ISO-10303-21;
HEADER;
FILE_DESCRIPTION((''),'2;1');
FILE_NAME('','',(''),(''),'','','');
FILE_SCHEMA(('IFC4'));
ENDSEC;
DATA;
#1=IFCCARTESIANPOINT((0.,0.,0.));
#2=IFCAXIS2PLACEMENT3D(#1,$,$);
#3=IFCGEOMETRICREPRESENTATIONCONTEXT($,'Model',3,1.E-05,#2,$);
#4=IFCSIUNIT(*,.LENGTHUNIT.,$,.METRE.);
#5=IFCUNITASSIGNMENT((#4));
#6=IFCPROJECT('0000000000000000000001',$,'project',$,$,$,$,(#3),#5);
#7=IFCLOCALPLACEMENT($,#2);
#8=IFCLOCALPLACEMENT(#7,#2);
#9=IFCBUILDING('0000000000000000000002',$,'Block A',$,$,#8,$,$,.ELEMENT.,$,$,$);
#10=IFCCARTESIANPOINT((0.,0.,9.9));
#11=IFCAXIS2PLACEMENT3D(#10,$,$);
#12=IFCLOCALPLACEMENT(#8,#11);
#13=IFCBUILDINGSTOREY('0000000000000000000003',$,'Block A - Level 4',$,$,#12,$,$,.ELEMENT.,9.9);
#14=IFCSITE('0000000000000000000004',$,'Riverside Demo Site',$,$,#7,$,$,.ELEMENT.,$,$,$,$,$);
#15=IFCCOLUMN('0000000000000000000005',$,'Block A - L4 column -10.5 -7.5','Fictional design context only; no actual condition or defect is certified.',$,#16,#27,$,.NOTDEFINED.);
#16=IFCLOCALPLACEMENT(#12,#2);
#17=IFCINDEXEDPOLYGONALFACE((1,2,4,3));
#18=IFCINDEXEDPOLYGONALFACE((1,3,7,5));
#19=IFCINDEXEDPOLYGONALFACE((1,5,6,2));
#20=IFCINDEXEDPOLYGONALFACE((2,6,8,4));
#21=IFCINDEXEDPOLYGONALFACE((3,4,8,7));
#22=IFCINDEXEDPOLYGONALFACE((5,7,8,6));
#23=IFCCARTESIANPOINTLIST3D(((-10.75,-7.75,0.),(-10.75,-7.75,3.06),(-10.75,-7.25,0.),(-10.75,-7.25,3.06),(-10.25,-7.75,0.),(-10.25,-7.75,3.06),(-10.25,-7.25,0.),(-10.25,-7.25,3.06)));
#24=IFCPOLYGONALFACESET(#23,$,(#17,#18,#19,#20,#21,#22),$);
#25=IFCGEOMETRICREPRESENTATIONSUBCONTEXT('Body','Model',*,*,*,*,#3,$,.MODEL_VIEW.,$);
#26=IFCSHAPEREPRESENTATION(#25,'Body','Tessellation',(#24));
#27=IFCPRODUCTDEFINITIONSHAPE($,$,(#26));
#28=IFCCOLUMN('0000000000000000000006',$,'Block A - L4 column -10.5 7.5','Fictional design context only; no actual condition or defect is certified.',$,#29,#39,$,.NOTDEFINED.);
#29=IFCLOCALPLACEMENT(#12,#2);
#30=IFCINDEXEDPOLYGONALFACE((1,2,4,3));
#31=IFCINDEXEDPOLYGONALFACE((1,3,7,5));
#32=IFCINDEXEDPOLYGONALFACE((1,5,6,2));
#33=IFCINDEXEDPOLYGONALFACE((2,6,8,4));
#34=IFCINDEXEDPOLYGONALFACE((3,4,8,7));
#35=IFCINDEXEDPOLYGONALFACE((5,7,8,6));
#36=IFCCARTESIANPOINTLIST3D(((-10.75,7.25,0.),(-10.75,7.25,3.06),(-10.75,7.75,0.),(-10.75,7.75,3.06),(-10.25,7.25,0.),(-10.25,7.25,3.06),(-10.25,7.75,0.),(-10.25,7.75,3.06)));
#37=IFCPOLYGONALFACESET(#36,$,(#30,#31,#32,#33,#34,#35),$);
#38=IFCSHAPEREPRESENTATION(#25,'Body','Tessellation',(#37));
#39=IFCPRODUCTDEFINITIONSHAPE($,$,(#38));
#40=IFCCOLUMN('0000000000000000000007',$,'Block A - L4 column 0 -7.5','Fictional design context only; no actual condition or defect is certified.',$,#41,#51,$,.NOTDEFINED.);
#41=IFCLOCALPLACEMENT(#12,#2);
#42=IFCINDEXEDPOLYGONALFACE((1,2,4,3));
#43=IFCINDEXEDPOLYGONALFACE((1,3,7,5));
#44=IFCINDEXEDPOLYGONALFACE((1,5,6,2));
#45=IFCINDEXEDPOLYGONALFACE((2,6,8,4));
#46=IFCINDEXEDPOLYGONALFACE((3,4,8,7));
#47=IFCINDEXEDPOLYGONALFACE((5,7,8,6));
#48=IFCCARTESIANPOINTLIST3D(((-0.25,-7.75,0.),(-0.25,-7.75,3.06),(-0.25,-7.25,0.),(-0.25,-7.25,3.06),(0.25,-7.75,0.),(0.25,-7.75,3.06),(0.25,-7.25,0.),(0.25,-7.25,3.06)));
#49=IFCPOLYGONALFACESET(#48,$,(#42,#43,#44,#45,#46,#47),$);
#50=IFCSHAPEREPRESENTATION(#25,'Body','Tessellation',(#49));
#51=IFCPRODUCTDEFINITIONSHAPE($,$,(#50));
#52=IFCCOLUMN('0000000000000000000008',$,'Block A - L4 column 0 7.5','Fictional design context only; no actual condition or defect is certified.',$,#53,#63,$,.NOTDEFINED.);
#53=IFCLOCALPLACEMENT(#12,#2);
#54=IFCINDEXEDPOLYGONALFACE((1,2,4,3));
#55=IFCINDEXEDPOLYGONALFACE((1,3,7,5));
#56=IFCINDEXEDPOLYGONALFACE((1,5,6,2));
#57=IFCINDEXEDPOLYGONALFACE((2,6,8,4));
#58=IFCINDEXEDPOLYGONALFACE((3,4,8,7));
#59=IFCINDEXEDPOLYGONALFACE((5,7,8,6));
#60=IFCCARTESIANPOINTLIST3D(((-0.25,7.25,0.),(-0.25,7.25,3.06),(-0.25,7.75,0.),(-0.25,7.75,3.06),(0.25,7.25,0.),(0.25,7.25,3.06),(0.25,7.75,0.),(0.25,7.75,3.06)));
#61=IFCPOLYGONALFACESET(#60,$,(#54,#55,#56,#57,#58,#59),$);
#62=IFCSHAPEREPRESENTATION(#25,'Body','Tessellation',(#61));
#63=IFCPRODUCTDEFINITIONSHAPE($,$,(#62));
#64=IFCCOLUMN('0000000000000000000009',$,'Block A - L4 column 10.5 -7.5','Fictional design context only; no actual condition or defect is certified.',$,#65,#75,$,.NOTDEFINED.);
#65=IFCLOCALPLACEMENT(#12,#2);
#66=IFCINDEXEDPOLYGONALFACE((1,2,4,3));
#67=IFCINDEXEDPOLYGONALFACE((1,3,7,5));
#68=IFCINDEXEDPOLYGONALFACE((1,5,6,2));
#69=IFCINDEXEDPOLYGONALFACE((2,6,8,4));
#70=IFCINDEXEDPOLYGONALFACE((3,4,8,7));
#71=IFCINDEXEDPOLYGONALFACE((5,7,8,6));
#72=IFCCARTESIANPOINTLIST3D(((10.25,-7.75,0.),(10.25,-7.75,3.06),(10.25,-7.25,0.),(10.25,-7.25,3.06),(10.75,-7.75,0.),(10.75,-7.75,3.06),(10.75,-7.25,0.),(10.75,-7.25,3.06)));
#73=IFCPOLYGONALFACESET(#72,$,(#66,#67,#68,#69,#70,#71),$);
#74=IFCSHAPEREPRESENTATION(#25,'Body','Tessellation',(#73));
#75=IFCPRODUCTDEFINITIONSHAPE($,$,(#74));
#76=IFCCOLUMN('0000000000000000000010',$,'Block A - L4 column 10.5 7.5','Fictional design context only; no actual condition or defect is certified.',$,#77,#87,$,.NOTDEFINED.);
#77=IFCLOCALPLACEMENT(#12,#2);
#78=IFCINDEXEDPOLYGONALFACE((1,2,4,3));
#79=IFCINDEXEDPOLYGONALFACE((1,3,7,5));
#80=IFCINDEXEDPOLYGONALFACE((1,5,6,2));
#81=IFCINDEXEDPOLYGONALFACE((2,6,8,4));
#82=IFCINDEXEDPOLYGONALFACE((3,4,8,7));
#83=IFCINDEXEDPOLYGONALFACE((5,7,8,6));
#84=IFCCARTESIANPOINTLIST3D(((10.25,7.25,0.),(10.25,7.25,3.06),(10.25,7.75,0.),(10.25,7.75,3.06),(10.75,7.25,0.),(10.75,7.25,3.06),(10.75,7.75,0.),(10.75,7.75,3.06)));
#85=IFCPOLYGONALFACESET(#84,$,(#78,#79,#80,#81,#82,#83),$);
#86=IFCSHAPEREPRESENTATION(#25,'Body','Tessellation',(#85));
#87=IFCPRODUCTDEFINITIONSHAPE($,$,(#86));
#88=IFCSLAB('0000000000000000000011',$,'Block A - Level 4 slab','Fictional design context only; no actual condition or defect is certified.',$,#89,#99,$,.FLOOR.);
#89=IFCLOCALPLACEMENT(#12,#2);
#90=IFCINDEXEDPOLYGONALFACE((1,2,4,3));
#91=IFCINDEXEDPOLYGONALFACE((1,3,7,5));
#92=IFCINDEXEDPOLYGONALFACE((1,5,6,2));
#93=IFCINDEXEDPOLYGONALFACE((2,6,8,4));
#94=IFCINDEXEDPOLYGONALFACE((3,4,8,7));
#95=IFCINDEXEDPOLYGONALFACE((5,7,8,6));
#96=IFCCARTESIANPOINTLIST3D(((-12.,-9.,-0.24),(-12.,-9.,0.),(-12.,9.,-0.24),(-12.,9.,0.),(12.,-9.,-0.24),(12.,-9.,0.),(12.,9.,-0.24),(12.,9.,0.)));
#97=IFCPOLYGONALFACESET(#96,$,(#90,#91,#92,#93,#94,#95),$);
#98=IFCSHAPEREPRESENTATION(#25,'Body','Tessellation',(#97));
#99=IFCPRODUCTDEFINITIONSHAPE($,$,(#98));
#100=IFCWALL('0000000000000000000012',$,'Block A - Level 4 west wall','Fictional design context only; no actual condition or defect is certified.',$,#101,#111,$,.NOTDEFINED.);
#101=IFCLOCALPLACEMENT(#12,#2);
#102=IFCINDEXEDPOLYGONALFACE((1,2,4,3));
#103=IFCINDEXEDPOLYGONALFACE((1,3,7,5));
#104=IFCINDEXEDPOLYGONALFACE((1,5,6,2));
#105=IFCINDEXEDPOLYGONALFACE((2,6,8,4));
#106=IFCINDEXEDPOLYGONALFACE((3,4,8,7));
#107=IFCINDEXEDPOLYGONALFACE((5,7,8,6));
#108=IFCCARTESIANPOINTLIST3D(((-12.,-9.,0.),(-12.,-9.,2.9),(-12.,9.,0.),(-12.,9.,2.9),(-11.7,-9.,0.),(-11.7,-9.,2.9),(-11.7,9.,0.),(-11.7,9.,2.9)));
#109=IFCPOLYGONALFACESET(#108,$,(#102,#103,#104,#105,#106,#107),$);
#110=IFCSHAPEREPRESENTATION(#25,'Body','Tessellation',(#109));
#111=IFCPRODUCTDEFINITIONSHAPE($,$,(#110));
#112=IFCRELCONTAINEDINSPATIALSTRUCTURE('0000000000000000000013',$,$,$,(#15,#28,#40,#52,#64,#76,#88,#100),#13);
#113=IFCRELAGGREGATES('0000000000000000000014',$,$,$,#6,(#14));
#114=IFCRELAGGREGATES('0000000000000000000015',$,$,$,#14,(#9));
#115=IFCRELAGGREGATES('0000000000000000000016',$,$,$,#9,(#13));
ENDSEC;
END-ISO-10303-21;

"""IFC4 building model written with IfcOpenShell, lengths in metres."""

from ifc_helpers import new_model, si_unit, frame, origin, origin_2d, place, context, subcontext, project, spatial, rectangle, extrude, element, save


model = new_model("IFC4")

# Units and contexts
model_context = context("Model", 3, precision=1e-05, world=origin())
body_context = subcontext(model_context, "Body", "Model", "MODEL_VIEW")
ifc_project = project(units=[si_unit("LENGTHUNIT", "METRE")], contexts=[model_context])

# Site, building, storey
site_placement = place(None, origin())
site = spatial("IfcSite", under=ifc_project, at=site_placement, Name="Riverside Demo Site", CompositionType="ELEMENT")
building_placement = place(site_placement, origin())
building = spatial("IfcBuilding", under=site, at=building_placement, Name="Block A", CompositionType="ELEMENT")
storey_placement = place(building_placement, frame((0.0, 0.0, 9.9)))
storey = spatial("IfcBuildingStorey", under=building, at=storey_placement, Name="Block A - Level 4", CompositionType="ELEMENT", Elevation=9.9)

# Columns
for number, where, name in (
    (1, (-10.5, -7.5, 0.0), "Block A - L4 column -10.5 -7.5"),
    (2, (-10.5, 7.5, 0.0), "Block A - L4 column -10.5 7.5"),
    (3, (0.0, -7.5, 0.0), "Block A - L4 column 0 -7.5"),
    (4, (0.0, 7.5, 0.0), "Block A - L4 column 0 7.5"),
    (5, (10.5, -7.5, 0.0), "Block A - L4 column 10.5 -7.5"),
    (6, (10.5, 7.5, 0.0), "Block A - L4 column 10.5 7.5"),
):
    element("IfcColumn", number, at=place(storey_placement, frame(where)), inside=storey, Name=name, Description="Fictional design context only; no actual condition or defect is certified.", PredefinedType="NOTDEFINED", context=body_context, shape_type="SweptSolid", body=[
        extrude(rectangle(XDim=0.5, YDim=0.5, at=origin_2d()), origin(), (0.0, 0.0, 1.0), 3.06),
    ])

# Slab
slab_placement = place(storey_placement, frame((0.0, 0.0, -0.24)))
element("IfcSlab", 7, at=slab_placement, inside=storey, Name="Block A - Level 4 slab", Description="Fictional design context only; no actual condition or defect is certified.", PredefinedType="FLOOR", context=body_context, shape_type="SweptSolid", body=[
    extrude(rectangle(XDim=24.0, YDim=18.0, at=origin_2d()), origin(), (0.0, 0.0, 1.0), 0.24),
])

# Wall
wall_placement = place(storey_placement, frame((-11.85, 0.0, 0.0)))
element("IfcWall", 8, at=wall_placement, inside=storey, Name="Block A - Level 4 west wall", Description="Fictional design context only; no actual condition or defect is certified.", PredefinedType="NOTDEFINED", context=body_context, shape_type="SweptSolid", body=[
    extrude(rectangle(XDim=0.3, YDim=18.0, at=origin_2d()), origin(), (0.0, 0.0, 1.0), 2.9),
])

save(model, "model.ifc")
